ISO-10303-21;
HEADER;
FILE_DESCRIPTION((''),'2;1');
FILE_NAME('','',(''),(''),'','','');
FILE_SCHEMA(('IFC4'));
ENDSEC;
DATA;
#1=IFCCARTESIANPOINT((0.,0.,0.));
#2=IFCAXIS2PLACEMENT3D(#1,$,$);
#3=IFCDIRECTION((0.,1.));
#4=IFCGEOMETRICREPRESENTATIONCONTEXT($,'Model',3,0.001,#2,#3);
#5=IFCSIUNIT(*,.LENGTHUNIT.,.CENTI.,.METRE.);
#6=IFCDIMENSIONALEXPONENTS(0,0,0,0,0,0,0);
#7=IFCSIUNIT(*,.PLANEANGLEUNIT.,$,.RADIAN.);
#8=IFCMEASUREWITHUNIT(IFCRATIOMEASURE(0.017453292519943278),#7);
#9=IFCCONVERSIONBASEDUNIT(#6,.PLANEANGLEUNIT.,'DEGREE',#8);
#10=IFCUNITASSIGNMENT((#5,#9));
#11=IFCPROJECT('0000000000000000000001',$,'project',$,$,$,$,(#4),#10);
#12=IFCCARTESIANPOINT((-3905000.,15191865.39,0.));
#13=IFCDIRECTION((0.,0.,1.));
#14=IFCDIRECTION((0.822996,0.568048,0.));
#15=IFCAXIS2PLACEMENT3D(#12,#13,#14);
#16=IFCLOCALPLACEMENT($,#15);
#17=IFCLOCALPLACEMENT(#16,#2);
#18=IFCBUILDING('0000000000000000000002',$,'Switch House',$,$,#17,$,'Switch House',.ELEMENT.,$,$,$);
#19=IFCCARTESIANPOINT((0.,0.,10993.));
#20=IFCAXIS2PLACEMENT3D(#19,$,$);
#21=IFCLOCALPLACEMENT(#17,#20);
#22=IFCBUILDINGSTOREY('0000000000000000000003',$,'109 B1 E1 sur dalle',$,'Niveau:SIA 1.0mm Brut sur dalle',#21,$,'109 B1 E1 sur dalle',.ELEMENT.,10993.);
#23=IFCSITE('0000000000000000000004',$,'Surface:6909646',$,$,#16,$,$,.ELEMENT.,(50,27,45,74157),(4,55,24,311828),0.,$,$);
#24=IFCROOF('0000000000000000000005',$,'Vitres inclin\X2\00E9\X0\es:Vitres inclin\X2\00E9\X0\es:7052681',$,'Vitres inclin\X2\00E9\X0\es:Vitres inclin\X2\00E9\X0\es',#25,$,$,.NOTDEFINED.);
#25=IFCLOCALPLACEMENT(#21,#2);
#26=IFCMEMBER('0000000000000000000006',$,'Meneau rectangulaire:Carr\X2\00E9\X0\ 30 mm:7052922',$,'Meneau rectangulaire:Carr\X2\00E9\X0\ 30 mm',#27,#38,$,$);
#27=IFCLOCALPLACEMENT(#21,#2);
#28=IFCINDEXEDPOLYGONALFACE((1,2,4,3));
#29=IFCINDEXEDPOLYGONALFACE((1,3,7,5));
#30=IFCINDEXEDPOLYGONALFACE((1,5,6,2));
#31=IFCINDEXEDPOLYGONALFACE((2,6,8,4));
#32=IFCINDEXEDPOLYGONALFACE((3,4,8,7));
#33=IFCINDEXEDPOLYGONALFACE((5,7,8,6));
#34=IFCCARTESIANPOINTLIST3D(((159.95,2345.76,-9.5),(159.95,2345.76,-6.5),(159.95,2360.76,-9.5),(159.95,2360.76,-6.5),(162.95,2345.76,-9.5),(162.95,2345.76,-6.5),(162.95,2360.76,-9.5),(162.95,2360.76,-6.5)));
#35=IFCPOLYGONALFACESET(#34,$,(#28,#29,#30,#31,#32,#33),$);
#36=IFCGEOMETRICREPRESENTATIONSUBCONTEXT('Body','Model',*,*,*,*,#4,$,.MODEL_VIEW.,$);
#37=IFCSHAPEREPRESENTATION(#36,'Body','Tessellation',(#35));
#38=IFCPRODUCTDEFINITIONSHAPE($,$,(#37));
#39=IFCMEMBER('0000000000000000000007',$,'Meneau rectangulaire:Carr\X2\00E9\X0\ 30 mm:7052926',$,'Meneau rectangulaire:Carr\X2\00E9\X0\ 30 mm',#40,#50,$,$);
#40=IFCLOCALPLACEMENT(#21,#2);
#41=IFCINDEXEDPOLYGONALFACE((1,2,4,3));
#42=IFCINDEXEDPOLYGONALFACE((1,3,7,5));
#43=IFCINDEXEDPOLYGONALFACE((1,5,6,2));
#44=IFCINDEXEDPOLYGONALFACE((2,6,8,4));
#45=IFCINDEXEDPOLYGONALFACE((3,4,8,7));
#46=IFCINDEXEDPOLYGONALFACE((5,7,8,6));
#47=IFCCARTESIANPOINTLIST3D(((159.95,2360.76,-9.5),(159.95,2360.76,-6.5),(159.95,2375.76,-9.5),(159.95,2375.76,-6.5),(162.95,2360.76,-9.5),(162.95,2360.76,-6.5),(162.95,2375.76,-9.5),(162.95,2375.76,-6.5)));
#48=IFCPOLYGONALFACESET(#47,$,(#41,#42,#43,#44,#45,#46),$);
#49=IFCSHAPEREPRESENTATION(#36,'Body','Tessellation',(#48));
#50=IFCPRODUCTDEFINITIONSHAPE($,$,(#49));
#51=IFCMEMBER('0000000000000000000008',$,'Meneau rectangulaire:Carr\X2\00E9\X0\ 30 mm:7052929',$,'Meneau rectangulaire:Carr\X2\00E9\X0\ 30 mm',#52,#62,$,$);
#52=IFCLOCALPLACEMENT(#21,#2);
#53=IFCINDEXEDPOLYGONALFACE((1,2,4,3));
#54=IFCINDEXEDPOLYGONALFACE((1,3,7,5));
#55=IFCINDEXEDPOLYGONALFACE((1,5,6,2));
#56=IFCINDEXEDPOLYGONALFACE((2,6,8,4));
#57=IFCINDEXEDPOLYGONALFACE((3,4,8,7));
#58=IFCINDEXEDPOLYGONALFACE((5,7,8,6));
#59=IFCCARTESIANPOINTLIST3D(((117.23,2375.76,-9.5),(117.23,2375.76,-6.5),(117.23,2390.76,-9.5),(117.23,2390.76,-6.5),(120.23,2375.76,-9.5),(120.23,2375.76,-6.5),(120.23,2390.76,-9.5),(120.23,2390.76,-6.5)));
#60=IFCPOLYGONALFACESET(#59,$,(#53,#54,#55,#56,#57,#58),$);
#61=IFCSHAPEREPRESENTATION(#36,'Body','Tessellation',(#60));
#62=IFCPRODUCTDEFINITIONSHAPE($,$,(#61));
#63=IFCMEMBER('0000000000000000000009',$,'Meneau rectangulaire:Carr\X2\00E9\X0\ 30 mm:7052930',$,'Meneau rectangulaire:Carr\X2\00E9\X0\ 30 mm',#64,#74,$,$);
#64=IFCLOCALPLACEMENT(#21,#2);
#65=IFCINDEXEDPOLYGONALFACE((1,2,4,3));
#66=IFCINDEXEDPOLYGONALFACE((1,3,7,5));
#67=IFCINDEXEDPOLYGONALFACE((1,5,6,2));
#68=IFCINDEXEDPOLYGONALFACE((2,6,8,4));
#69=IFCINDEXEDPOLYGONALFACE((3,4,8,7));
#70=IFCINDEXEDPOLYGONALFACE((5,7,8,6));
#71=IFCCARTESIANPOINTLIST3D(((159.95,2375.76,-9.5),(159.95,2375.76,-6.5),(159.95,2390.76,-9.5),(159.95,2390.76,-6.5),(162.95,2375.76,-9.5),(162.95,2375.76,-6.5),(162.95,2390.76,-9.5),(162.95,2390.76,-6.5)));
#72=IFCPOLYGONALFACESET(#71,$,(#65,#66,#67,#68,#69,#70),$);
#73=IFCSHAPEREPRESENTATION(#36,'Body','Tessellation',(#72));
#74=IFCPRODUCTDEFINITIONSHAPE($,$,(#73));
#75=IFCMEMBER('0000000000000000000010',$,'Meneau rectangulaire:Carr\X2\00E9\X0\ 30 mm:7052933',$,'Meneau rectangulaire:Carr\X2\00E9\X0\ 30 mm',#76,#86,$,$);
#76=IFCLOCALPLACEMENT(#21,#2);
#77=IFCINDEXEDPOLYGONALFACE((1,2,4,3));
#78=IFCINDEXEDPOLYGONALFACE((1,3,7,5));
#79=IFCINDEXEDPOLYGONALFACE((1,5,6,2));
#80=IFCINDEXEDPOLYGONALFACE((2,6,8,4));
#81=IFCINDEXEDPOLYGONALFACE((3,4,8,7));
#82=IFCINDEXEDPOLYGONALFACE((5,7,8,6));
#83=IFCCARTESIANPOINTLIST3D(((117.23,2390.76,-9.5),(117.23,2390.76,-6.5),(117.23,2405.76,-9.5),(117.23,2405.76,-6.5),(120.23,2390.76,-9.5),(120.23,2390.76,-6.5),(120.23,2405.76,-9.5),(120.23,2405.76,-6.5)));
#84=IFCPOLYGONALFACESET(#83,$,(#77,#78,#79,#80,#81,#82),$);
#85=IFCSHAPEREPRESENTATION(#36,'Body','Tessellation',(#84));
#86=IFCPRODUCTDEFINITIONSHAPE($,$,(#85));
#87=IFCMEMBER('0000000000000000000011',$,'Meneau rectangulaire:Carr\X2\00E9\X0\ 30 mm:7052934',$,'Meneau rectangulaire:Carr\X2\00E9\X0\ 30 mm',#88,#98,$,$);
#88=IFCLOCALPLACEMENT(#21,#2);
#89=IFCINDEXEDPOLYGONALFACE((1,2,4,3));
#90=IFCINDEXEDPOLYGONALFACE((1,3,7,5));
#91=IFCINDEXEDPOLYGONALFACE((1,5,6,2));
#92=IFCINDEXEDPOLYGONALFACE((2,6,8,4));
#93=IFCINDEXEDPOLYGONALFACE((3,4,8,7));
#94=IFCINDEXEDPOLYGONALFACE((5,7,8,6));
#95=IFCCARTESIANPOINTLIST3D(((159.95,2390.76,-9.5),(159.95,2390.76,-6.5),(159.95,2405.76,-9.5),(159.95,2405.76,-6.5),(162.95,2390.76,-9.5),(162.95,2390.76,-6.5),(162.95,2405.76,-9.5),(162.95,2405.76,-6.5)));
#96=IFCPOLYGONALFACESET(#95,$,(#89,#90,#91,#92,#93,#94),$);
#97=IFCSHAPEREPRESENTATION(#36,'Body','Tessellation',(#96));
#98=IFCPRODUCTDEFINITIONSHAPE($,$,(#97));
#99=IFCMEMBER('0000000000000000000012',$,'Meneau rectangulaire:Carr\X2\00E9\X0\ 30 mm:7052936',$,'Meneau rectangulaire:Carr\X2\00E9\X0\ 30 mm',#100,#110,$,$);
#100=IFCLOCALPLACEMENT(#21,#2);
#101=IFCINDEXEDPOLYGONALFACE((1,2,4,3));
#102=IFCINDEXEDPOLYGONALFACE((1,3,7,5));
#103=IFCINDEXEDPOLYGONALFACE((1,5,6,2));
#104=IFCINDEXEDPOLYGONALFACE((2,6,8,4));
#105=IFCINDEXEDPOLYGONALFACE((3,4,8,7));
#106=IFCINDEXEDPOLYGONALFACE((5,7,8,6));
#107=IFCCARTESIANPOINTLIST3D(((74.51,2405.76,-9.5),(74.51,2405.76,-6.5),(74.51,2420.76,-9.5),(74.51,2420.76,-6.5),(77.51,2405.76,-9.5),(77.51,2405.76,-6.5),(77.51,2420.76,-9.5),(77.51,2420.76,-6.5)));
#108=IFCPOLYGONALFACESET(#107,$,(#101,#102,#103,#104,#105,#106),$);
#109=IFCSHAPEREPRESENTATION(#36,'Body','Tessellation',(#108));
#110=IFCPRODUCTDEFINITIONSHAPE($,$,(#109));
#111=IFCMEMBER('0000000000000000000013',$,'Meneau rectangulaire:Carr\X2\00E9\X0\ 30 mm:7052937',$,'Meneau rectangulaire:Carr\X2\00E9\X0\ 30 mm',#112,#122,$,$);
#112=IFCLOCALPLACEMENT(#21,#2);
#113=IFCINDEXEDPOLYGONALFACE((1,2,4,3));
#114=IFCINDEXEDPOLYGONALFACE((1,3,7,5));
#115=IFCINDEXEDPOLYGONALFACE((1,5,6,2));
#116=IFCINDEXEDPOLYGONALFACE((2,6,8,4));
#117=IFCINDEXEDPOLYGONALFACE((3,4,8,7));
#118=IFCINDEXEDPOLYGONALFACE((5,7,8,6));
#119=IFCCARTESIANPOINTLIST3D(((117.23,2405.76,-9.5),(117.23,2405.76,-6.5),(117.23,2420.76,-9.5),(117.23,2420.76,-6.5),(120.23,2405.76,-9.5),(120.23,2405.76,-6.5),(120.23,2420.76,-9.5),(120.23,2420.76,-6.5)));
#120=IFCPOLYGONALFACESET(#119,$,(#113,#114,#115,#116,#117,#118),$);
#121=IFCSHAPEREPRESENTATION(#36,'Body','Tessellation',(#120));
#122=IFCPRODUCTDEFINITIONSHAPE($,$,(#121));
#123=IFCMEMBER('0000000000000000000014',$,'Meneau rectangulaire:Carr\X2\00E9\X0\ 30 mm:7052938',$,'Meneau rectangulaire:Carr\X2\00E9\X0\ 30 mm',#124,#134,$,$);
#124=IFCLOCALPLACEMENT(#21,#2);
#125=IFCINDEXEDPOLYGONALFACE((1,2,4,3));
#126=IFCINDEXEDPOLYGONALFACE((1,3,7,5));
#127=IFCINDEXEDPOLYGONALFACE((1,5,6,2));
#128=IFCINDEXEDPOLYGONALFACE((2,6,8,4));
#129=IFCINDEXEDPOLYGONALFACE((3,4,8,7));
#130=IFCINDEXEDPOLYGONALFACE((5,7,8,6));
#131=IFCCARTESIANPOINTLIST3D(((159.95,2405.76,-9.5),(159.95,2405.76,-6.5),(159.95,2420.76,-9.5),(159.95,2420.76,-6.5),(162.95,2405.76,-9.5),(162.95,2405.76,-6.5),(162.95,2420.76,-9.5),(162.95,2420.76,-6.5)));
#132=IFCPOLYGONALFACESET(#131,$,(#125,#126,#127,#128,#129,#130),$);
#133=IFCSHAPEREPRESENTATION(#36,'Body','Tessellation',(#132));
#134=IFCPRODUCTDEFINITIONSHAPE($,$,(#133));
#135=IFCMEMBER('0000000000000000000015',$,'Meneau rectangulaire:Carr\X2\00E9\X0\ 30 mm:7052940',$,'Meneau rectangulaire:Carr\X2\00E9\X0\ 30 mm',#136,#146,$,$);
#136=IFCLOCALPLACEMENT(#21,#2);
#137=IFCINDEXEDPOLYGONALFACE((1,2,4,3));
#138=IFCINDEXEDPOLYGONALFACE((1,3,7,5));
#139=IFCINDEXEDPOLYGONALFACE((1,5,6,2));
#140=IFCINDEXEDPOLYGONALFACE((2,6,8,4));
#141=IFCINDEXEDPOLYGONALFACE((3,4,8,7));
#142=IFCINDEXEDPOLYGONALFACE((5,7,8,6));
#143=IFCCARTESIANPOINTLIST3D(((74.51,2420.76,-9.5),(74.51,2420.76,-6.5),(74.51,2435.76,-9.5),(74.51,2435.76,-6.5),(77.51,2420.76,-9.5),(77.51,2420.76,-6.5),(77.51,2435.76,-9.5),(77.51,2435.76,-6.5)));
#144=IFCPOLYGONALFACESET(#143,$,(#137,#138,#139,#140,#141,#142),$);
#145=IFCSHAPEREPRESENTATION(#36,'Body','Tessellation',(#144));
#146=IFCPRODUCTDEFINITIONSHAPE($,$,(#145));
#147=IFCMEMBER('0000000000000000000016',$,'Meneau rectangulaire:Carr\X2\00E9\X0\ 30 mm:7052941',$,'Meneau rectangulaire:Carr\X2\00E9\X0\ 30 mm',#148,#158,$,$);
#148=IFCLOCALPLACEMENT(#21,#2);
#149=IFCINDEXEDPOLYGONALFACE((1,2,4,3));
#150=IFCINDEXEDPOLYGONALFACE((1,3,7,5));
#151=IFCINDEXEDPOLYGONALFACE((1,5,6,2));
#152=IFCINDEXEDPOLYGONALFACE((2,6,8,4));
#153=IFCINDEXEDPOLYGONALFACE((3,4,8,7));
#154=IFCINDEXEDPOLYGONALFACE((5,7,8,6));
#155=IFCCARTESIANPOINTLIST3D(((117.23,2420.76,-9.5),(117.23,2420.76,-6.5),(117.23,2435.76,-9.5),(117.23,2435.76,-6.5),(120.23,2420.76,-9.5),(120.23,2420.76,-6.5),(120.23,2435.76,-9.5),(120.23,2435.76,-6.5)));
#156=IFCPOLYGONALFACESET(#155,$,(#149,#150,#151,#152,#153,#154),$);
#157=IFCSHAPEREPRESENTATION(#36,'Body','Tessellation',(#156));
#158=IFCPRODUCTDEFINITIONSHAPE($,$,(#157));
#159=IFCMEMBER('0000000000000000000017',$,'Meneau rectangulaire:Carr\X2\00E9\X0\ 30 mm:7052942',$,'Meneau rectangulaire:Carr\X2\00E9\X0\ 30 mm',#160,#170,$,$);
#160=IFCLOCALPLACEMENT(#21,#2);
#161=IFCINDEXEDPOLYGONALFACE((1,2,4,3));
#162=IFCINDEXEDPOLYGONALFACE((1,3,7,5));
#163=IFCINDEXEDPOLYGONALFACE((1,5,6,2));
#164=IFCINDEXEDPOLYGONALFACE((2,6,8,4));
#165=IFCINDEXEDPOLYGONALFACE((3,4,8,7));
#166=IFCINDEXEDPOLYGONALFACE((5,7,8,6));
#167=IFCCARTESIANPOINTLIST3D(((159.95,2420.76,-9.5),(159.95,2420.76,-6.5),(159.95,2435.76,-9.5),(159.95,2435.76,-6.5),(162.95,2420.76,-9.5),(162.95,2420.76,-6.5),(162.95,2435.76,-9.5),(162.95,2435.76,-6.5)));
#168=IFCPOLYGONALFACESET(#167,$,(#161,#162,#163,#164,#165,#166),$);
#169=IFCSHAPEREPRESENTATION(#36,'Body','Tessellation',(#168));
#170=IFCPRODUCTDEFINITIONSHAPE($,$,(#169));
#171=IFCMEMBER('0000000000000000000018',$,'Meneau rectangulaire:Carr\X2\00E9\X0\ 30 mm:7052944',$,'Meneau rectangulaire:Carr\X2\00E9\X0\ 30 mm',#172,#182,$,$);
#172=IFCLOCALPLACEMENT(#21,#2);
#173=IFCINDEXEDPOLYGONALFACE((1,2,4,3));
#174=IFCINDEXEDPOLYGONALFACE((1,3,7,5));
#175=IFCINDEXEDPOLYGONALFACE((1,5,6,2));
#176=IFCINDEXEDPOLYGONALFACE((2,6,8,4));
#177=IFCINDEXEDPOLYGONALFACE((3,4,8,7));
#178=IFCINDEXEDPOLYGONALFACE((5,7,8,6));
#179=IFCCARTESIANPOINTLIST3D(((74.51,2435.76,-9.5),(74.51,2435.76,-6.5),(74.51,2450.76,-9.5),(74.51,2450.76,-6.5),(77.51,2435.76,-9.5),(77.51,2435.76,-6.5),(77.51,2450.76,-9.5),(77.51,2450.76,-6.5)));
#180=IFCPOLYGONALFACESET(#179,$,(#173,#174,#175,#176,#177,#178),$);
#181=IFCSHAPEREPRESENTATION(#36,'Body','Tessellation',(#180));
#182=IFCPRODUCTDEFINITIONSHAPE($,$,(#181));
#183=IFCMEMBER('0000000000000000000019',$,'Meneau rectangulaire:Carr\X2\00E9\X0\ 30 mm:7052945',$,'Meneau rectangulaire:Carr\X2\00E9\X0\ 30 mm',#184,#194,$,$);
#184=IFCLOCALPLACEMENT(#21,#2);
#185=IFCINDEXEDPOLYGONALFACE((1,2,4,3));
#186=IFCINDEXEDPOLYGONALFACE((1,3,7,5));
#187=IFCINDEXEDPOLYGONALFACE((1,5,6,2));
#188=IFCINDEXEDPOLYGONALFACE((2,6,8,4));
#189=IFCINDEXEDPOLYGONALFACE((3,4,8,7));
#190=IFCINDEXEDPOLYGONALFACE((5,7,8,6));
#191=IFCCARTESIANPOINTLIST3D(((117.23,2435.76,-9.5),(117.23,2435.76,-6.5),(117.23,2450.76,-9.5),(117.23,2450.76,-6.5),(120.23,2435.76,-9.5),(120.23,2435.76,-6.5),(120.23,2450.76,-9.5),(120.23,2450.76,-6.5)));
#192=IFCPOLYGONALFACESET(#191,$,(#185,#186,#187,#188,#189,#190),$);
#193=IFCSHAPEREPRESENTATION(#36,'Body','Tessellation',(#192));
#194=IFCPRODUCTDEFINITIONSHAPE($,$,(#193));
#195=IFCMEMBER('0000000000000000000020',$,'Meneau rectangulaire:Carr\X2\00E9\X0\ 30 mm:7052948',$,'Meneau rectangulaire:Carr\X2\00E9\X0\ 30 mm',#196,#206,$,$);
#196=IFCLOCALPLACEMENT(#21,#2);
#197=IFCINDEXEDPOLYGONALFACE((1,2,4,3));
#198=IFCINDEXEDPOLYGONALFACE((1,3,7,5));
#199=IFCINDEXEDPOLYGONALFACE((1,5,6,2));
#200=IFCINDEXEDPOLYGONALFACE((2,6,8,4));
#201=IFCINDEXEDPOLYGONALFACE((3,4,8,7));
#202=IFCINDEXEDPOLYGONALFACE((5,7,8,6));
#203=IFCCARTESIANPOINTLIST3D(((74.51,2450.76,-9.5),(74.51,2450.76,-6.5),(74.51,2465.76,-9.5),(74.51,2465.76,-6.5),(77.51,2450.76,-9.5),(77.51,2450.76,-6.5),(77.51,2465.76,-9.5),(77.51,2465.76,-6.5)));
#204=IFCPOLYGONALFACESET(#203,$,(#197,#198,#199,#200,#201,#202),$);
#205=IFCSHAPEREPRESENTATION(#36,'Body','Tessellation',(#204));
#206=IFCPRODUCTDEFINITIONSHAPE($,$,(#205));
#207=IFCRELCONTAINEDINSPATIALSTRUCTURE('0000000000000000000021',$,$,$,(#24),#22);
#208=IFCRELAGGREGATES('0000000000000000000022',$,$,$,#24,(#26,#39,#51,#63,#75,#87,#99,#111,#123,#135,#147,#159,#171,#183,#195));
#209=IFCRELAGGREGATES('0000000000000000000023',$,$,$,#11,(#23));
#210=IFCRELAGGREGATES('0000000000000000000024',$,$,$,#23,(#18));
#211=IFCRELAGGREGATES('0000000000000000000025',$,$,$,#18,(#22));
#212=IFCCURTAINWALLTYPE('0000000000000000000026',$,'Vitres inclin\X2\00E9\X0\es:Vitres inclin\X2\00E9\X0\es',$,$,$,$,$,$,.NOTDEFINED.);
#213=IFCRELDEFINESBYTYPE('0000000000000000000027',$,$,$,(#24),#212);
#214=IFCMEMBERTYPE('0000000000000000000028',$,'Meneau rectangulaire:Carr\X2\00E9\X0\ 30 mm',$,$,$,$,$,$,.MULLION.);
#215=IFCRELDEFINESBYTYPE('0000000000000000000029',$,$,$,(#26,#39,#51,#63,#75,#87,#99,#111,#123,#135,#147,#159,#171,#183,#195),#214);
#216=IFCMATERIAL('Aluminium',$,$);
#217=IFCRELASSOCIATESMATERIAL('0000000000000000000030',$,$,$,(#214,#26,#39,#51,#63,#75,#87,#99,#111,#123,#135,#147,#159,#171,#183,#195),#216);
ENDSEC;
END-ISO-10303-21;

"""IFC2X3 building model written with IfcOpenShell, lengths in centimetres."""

from ifc_helpers import new_model, entity, si_unit, converted_unit, direction, frame, origin, origin_2d_with_axis, place, context, subcontext, project, spatial, rectangle, extrude, source, transform, mapped, material, type_object, type_shapes, element, aggregate, save


model = new_model("IFC2X3")

# Units and contexts
model_context = context("Model", 3, precision=0.001, world=origin(), true_north=direction((0.0, 1.0)))
body_context = subcontext(model_context, "Body", "Model", "MODEL_VIEW")
ifc_project = project(units=[si_unit("LENGTHUNIT", "METRE", prefix="CENTI"), converted_unit("PLANEANGLEUNIT", "DEGREE", entity("IfcRatioMeasure", 0.017453292519943278), si_unit("PLANEANGLEUNIT", "RADIAN"), dimensions=[0, 0, 0, 0, 0, 0, 0])], contexts=[model_context])

# Site, building, storey
site_placement = place(None, frame((-3905000.0, 15191865.39, 0.0), z_axis=(0.0, 0.0, 1.0), x_axis=(0.822996, 0.568048, 0.0)))
site = spatial("IfcSite", under=ifc_project, at=site_placement, Name="Surface:6909646", CompositionType="ELEMENT", RefLatitude=(50, 27, 45, 74157), RefLongitude=(4, 55, 24, 311828), RefElevation=0.0)
building_placement = place(site_placement, origin())
building = spatial("IfcBuilding", under=site, at=building_placement, Name="Switch House", LongName="Switch House", CompositionType="ELEMENT")
storey_placement = place(building_placement, frame((0.0, 0.0, 10993.0)))
storey = spatial("IfcBuildingStorey", under=building, at=storey_placement, Name="109 B1 E1 sur dalle", ObjectType="Niveau:SIA 1.0mm Brut sur dalle", LongName="109 B1 E1 sur dalle", CompositionType="ELEMENT", Elevation=10993.0)

# Roof, members
curtain_wall_type = type_object("IfcCurtainWallType", Name="Vitres inclinées:Vitres inclinées", PredefinedType="NOTDEFINED")
roof_placement = place(storey_placement, frame((0.0, 0.0, -10993.0)))
roof = element("IfcRoof", 1, at=roof_placement, inside=storey, type_object=curtain_wall_type, Name="Vitres inclinées:Vitres inclinées:7052681", ObjectType="Vitres inclinées:Vitres inclinées", ShapeType="NOTDEFINED")
ifc_material = material(Name="Aluminium")
member_type_1 = type_object("IfcMemberType", Name="Meneau rectangulaire:Carré 30 mm", PredefinedType="MULLION", material=ifc_material)
shared_shape_1 = source(origin(), body_context, "Body", "SweptSolid", [
    extrude(rectangle(XDim=3.0, YDim=3.0, at=origin_2d_with_axis()), frame((0.0, 0.0, -15.0), z_axis=(0.0, 0.0, 1.0), x_axis=(0.0, -1.0, 0.0)), (0.0, 0.0, 1.0), 15.0),
])
type_shapes(member_type_1, [shared_shape_1])
member_1_placement = place(roof_placement, frame((161.45, 2360.76, 10985.0), z_axis=(0.0, 1.0, 0.0), x_axis=(1.0, 0.0, 0.0)))
member_1 = element("IfcMember", 2, at=member_1_placement, type_object=member_type_1, material=ifc_material, Name="Meneau rectangulaire:Carré 30 mm:7052922", ObjectType="Meneau rectangulaire:Carré 30 mm", context=body_context, shape_type="MappedRepresentation", body=[
    mapped(shared_shape_1, transform((0.0, 0.0, 0.0), scale=1.0)),
])
member_2_placement = place(roof_placement, frame((161.45, 2375.76, 10985.0), z_axis=(0.0, 1.0, 0.0), x_axis=(1.0, 0.0, 0.0)))
member_2 = element("IfcMember", 3, at=member_2_placement, type_object=member_type_1, material=ifc_material, Name="Meneau rectangulaire:Carré 30 mm:7052926", ObjectType="Meneau rectangulaire:Carré 30 mm", context=body_context, shape_type="MappedRepresentation", body=[
    mapped(shared_shape_1, transform((0.0, 0.0, 0.0), scale=1.0)),
])
member_3_placement = place(roof_placement, frame((118.73, 2390.76, 10985.0), z_axis=(0.0, 1.0, 0.0), x_axis=(1.0, 0.0, 0.0)))
member_3 = element("IfcMember", 4, at=member_3_placement, type_object=member_type_1, material=ifc_material, Name="Meneau rectangulaire:Carré 30 mm:7052929", ObjectType="Meneau rectangulaire:Carré 30 mm", context=body_context, shape_type="MappedRepresentation", body=[
    mapped(shared_shape_1, transform((0.0, 0.0, 0.0), scale=1.0)),
])
member_4_placement = place(roof_placement, frame((161.45, 2390.76, 10985.0), z_axis=(0.0, 1.0, 0.0), x_axis=(1.0, 0.0, 0.0)))
member_4 = element("IfcMember", 5, at=member_4_placement, type_object=member_type_1, material=ifc_material, Name="Meneau rectangulaire:Carré 30 mm:7052930", ObjectType="Meneau rectangulaire:Carré 30 mm", context=body_context, shape_type="MappedRepresentation", body=[
    mapped(shared_shape_1, transform((0.0, 0.0, 0.0), scale=1.0)),
])
member_5_placement = place(roof_placement, frame((118.73, 2405.76, 10985.0), z_axis=(0.0, 1.0, 0.0), x_axis=(1.0, 0.0, 0.0)))
member_5 = element("IfcMember", 6, at=member_5_placement, type_object=member_type_1, material=ifc_material, Name="Meneau rectangulaire:Carré 30 mm:7052933", ObjectType="Meneau rectangulaire:Carré 30 mm", context=body_context, shape_type="MappedRepresentation", body=[
    mapped(shared_shape_1, transform((0.0, 0.0, 0.0), scale=1.0)),
])
member_6_placement = place(roof_placement, frame((161.45, 2405.76, 10985.0), z_axis=(0.0, 1.0, 0.0), x_axis=(1.0, 0.0, 0.0)))
member_6 = element("IfcMember", 7, at=member_6_placement, type_object=member_type_1, material=ifc_material, Name="Meneau rectangulaire:Carré 30 mm:7052934", ObjectType="Meneau rectangulaire:Carré 30 mm", context=body_context, shape_type="MappedRepresentation", body=[
    mapped(shared_shape_1, transform((0.0, 0.0, 0.0), scale=1.0)),
])
member_7_placement = place(roof_placement, frame((76.01, 2420.76, 10985.0), z_axis=(0.0, 1.0, 0.0), x_axis=(1.0, 0.0, 0.0)))
member_7 = element("IfcMember", 8, at=member_7_placement, type_object=member_type_1, material=ifc_material, Name="Meneau rectangulaire:Carré 30 mm:7052936", ObjectType="Meneau rectangulaire:Carré 30 mm", context=body_context, shape_type="MappedRepresentation", body=[
    mapped(shared_shape_1, transform((0.0, 0.0, 0.0), scale=1.0)),
])
member_8_placement = place(roof_placement, frame((118.73, 2420.76, 10985.0), z_axis=(0.0, 1.0, 0.0), x_axis=(1.0, 0.0, 0.0)))
member_8 = element("IfcMember", 9, at=member_8_placement, type_object=member_type_1, material=ifc_material, Name="Meneau rectangulaire:Carré 30 mm:7052937", ObjectType="Meneau rectangulaire:Carré 30 mm", context=body_context, shape_type="MappedRepresentation", body=[
    mapped(shared_shape_1, transform((0.0, 0.0, 0.0), scale=1.0)),
])
member_9_placement = place(roof_placement, frame((161.45, 2420.76, 10985.0), z_axis=(0.0, 1.0, 0.0), x_axis=(1.0, 0.0, 0.0)))
member_9 = element("IfcMember", 10, at=member_9_placement, type_object=member_type_1, material=ifc_material, Name="Meneau rectangulaire:Carré 30 mm:7052938", ObjectType="Meneau rectangulaire:Carré 30 mm", context=body_context, shape_type="MappedRepresentation", body=[
    mapped(shared_shape_1, transform((0.0, 0.0, 0.0), scale=1.0)),
])
member_10_placement = place(roof_placement, frame((76.01, 2435.76, 10985.0), z_axis=(0.0, 1.0, 0.0), x_axis=(1.0, 0.0, 0.0)))
member_10 = element("IfcMember", 11, at=member_10_placement, type_object=member_type_1, material=ifc_material, Name="Meneau rectangulaire:Carré 30 mm:7052940", ObjectType="Meneau rectangulaire:Carré 30 mm", context=body_context, shape_type="MappedRepresentation", body=[
    mapped(shared_shape_1, transform((0.0, 0.0, 0.0), scale=1.0)),
])
member_11_placement = place(roof_placement, frame((118.73, 2435.76, 10985.0), z_axis=(0.0, 1.0, 0.0), x_axis=(1.0, 0.0, 0.0)))
member_11 = element("IfcMember", 12, at=member_11_placement, type_object=member_type_1, material=ifc_material, Name="Meneau rectangulaire:Carré 30 mm:7052941", ObjectType="Meneau rectangulaire:Carré 30 mm", context=body_context, shape_type="MappedRepresentation", body=[
    mapped(shared_shape_1, transform((0.0, 0.0, 0.0), scale=1.0)),
])
member_12_placement = place(roof_placement, frame((161.45, 2435.76, 10985.0), z_axis=(0.0, 1.0, 0.0), x_axis=(1.0, 0.0, 0.0)))
member_12 = element("IfcMember", 13, at=member_12_placement, type_object=member_type_1, material=ifc_material, Name="Meneau rectangulaire:Carré 30 mm:7052942", ObjectType="Meneau rectangulaire:Carré 30 mm", context=body_context, shape_type="MappedRepresentation", body=[
    mapped(shared_shape_1, transform((0.0, 0.0, 0.0), scale=1.0)),
])
member_13_placement = place(roof_placement, frame((76.01, 2450.76, 10985.0), z_axis=(0.0, 1.0, 0.0), x_axis=(1.0, 0.0, 0.0)))
member_13 = element("IfcMember", 14, at=member_13_placement, type_object=member_type_1, material=ifc_material, Name="Meneau rectangulaire:Carré 30 mm:7052944", ObjectType="Meneau rectangulaire:Carré 30 mm", context=body_context, shape_type="MappedRepresentation", body=[
    mapped(shared_shape_1, transform((0.0, 0.0, 0.0), scale=1.0)),
])
member_14_placement = place(roof_placement, frame((118.73, 2450.76, 10985.0), z_axis=(0.0, 1.0, 0.0), x_axis=(1.0, 0.0, 0.0)))
member_14 = element("IfcMember", 15, at=member_14_placement, type_object=member_type_1, material=ifc_material, Name="Meneau rectangulaire:Carré 30 mm:7052945", ObjectType="Meneau rectangulaire:Carré 30 mm", context=body_context, shape_type="MappedRepresentation", body=[
    mapped(shared_shape_1, transform((0.0, 0.0, 0.0), scale=1.0)),
])
member_15_placement = place(roof_placement, frame((76.01, 2465.76, 10985.0), z_axis=(0.0, 1.0, 0.0), x_axis=(1.0, 0.0, 0.0)))
member_15 = element("IfcMember", 16, at=member_15_placement, type_object=member_type_1, material=ifc_material, Name="Meneau rectangulaire:Carré 30 mm:7052948", ObjectType="Meneau rectangulaire:Carré 30 mm", context=body_context, shape_type="MappedRepresentation", body=[
    mapped(shared_shape_1, transform((0.0, 0.0, 0.0), scale=1.0)),
])
aggregate(roof, [member_1, member_2, member_3, member_4, member_5, member_6, member_7, member_8, member_9, member_10, member_11, member_12, member_13, member_14, member_15])

save(model, "model.ifc")
